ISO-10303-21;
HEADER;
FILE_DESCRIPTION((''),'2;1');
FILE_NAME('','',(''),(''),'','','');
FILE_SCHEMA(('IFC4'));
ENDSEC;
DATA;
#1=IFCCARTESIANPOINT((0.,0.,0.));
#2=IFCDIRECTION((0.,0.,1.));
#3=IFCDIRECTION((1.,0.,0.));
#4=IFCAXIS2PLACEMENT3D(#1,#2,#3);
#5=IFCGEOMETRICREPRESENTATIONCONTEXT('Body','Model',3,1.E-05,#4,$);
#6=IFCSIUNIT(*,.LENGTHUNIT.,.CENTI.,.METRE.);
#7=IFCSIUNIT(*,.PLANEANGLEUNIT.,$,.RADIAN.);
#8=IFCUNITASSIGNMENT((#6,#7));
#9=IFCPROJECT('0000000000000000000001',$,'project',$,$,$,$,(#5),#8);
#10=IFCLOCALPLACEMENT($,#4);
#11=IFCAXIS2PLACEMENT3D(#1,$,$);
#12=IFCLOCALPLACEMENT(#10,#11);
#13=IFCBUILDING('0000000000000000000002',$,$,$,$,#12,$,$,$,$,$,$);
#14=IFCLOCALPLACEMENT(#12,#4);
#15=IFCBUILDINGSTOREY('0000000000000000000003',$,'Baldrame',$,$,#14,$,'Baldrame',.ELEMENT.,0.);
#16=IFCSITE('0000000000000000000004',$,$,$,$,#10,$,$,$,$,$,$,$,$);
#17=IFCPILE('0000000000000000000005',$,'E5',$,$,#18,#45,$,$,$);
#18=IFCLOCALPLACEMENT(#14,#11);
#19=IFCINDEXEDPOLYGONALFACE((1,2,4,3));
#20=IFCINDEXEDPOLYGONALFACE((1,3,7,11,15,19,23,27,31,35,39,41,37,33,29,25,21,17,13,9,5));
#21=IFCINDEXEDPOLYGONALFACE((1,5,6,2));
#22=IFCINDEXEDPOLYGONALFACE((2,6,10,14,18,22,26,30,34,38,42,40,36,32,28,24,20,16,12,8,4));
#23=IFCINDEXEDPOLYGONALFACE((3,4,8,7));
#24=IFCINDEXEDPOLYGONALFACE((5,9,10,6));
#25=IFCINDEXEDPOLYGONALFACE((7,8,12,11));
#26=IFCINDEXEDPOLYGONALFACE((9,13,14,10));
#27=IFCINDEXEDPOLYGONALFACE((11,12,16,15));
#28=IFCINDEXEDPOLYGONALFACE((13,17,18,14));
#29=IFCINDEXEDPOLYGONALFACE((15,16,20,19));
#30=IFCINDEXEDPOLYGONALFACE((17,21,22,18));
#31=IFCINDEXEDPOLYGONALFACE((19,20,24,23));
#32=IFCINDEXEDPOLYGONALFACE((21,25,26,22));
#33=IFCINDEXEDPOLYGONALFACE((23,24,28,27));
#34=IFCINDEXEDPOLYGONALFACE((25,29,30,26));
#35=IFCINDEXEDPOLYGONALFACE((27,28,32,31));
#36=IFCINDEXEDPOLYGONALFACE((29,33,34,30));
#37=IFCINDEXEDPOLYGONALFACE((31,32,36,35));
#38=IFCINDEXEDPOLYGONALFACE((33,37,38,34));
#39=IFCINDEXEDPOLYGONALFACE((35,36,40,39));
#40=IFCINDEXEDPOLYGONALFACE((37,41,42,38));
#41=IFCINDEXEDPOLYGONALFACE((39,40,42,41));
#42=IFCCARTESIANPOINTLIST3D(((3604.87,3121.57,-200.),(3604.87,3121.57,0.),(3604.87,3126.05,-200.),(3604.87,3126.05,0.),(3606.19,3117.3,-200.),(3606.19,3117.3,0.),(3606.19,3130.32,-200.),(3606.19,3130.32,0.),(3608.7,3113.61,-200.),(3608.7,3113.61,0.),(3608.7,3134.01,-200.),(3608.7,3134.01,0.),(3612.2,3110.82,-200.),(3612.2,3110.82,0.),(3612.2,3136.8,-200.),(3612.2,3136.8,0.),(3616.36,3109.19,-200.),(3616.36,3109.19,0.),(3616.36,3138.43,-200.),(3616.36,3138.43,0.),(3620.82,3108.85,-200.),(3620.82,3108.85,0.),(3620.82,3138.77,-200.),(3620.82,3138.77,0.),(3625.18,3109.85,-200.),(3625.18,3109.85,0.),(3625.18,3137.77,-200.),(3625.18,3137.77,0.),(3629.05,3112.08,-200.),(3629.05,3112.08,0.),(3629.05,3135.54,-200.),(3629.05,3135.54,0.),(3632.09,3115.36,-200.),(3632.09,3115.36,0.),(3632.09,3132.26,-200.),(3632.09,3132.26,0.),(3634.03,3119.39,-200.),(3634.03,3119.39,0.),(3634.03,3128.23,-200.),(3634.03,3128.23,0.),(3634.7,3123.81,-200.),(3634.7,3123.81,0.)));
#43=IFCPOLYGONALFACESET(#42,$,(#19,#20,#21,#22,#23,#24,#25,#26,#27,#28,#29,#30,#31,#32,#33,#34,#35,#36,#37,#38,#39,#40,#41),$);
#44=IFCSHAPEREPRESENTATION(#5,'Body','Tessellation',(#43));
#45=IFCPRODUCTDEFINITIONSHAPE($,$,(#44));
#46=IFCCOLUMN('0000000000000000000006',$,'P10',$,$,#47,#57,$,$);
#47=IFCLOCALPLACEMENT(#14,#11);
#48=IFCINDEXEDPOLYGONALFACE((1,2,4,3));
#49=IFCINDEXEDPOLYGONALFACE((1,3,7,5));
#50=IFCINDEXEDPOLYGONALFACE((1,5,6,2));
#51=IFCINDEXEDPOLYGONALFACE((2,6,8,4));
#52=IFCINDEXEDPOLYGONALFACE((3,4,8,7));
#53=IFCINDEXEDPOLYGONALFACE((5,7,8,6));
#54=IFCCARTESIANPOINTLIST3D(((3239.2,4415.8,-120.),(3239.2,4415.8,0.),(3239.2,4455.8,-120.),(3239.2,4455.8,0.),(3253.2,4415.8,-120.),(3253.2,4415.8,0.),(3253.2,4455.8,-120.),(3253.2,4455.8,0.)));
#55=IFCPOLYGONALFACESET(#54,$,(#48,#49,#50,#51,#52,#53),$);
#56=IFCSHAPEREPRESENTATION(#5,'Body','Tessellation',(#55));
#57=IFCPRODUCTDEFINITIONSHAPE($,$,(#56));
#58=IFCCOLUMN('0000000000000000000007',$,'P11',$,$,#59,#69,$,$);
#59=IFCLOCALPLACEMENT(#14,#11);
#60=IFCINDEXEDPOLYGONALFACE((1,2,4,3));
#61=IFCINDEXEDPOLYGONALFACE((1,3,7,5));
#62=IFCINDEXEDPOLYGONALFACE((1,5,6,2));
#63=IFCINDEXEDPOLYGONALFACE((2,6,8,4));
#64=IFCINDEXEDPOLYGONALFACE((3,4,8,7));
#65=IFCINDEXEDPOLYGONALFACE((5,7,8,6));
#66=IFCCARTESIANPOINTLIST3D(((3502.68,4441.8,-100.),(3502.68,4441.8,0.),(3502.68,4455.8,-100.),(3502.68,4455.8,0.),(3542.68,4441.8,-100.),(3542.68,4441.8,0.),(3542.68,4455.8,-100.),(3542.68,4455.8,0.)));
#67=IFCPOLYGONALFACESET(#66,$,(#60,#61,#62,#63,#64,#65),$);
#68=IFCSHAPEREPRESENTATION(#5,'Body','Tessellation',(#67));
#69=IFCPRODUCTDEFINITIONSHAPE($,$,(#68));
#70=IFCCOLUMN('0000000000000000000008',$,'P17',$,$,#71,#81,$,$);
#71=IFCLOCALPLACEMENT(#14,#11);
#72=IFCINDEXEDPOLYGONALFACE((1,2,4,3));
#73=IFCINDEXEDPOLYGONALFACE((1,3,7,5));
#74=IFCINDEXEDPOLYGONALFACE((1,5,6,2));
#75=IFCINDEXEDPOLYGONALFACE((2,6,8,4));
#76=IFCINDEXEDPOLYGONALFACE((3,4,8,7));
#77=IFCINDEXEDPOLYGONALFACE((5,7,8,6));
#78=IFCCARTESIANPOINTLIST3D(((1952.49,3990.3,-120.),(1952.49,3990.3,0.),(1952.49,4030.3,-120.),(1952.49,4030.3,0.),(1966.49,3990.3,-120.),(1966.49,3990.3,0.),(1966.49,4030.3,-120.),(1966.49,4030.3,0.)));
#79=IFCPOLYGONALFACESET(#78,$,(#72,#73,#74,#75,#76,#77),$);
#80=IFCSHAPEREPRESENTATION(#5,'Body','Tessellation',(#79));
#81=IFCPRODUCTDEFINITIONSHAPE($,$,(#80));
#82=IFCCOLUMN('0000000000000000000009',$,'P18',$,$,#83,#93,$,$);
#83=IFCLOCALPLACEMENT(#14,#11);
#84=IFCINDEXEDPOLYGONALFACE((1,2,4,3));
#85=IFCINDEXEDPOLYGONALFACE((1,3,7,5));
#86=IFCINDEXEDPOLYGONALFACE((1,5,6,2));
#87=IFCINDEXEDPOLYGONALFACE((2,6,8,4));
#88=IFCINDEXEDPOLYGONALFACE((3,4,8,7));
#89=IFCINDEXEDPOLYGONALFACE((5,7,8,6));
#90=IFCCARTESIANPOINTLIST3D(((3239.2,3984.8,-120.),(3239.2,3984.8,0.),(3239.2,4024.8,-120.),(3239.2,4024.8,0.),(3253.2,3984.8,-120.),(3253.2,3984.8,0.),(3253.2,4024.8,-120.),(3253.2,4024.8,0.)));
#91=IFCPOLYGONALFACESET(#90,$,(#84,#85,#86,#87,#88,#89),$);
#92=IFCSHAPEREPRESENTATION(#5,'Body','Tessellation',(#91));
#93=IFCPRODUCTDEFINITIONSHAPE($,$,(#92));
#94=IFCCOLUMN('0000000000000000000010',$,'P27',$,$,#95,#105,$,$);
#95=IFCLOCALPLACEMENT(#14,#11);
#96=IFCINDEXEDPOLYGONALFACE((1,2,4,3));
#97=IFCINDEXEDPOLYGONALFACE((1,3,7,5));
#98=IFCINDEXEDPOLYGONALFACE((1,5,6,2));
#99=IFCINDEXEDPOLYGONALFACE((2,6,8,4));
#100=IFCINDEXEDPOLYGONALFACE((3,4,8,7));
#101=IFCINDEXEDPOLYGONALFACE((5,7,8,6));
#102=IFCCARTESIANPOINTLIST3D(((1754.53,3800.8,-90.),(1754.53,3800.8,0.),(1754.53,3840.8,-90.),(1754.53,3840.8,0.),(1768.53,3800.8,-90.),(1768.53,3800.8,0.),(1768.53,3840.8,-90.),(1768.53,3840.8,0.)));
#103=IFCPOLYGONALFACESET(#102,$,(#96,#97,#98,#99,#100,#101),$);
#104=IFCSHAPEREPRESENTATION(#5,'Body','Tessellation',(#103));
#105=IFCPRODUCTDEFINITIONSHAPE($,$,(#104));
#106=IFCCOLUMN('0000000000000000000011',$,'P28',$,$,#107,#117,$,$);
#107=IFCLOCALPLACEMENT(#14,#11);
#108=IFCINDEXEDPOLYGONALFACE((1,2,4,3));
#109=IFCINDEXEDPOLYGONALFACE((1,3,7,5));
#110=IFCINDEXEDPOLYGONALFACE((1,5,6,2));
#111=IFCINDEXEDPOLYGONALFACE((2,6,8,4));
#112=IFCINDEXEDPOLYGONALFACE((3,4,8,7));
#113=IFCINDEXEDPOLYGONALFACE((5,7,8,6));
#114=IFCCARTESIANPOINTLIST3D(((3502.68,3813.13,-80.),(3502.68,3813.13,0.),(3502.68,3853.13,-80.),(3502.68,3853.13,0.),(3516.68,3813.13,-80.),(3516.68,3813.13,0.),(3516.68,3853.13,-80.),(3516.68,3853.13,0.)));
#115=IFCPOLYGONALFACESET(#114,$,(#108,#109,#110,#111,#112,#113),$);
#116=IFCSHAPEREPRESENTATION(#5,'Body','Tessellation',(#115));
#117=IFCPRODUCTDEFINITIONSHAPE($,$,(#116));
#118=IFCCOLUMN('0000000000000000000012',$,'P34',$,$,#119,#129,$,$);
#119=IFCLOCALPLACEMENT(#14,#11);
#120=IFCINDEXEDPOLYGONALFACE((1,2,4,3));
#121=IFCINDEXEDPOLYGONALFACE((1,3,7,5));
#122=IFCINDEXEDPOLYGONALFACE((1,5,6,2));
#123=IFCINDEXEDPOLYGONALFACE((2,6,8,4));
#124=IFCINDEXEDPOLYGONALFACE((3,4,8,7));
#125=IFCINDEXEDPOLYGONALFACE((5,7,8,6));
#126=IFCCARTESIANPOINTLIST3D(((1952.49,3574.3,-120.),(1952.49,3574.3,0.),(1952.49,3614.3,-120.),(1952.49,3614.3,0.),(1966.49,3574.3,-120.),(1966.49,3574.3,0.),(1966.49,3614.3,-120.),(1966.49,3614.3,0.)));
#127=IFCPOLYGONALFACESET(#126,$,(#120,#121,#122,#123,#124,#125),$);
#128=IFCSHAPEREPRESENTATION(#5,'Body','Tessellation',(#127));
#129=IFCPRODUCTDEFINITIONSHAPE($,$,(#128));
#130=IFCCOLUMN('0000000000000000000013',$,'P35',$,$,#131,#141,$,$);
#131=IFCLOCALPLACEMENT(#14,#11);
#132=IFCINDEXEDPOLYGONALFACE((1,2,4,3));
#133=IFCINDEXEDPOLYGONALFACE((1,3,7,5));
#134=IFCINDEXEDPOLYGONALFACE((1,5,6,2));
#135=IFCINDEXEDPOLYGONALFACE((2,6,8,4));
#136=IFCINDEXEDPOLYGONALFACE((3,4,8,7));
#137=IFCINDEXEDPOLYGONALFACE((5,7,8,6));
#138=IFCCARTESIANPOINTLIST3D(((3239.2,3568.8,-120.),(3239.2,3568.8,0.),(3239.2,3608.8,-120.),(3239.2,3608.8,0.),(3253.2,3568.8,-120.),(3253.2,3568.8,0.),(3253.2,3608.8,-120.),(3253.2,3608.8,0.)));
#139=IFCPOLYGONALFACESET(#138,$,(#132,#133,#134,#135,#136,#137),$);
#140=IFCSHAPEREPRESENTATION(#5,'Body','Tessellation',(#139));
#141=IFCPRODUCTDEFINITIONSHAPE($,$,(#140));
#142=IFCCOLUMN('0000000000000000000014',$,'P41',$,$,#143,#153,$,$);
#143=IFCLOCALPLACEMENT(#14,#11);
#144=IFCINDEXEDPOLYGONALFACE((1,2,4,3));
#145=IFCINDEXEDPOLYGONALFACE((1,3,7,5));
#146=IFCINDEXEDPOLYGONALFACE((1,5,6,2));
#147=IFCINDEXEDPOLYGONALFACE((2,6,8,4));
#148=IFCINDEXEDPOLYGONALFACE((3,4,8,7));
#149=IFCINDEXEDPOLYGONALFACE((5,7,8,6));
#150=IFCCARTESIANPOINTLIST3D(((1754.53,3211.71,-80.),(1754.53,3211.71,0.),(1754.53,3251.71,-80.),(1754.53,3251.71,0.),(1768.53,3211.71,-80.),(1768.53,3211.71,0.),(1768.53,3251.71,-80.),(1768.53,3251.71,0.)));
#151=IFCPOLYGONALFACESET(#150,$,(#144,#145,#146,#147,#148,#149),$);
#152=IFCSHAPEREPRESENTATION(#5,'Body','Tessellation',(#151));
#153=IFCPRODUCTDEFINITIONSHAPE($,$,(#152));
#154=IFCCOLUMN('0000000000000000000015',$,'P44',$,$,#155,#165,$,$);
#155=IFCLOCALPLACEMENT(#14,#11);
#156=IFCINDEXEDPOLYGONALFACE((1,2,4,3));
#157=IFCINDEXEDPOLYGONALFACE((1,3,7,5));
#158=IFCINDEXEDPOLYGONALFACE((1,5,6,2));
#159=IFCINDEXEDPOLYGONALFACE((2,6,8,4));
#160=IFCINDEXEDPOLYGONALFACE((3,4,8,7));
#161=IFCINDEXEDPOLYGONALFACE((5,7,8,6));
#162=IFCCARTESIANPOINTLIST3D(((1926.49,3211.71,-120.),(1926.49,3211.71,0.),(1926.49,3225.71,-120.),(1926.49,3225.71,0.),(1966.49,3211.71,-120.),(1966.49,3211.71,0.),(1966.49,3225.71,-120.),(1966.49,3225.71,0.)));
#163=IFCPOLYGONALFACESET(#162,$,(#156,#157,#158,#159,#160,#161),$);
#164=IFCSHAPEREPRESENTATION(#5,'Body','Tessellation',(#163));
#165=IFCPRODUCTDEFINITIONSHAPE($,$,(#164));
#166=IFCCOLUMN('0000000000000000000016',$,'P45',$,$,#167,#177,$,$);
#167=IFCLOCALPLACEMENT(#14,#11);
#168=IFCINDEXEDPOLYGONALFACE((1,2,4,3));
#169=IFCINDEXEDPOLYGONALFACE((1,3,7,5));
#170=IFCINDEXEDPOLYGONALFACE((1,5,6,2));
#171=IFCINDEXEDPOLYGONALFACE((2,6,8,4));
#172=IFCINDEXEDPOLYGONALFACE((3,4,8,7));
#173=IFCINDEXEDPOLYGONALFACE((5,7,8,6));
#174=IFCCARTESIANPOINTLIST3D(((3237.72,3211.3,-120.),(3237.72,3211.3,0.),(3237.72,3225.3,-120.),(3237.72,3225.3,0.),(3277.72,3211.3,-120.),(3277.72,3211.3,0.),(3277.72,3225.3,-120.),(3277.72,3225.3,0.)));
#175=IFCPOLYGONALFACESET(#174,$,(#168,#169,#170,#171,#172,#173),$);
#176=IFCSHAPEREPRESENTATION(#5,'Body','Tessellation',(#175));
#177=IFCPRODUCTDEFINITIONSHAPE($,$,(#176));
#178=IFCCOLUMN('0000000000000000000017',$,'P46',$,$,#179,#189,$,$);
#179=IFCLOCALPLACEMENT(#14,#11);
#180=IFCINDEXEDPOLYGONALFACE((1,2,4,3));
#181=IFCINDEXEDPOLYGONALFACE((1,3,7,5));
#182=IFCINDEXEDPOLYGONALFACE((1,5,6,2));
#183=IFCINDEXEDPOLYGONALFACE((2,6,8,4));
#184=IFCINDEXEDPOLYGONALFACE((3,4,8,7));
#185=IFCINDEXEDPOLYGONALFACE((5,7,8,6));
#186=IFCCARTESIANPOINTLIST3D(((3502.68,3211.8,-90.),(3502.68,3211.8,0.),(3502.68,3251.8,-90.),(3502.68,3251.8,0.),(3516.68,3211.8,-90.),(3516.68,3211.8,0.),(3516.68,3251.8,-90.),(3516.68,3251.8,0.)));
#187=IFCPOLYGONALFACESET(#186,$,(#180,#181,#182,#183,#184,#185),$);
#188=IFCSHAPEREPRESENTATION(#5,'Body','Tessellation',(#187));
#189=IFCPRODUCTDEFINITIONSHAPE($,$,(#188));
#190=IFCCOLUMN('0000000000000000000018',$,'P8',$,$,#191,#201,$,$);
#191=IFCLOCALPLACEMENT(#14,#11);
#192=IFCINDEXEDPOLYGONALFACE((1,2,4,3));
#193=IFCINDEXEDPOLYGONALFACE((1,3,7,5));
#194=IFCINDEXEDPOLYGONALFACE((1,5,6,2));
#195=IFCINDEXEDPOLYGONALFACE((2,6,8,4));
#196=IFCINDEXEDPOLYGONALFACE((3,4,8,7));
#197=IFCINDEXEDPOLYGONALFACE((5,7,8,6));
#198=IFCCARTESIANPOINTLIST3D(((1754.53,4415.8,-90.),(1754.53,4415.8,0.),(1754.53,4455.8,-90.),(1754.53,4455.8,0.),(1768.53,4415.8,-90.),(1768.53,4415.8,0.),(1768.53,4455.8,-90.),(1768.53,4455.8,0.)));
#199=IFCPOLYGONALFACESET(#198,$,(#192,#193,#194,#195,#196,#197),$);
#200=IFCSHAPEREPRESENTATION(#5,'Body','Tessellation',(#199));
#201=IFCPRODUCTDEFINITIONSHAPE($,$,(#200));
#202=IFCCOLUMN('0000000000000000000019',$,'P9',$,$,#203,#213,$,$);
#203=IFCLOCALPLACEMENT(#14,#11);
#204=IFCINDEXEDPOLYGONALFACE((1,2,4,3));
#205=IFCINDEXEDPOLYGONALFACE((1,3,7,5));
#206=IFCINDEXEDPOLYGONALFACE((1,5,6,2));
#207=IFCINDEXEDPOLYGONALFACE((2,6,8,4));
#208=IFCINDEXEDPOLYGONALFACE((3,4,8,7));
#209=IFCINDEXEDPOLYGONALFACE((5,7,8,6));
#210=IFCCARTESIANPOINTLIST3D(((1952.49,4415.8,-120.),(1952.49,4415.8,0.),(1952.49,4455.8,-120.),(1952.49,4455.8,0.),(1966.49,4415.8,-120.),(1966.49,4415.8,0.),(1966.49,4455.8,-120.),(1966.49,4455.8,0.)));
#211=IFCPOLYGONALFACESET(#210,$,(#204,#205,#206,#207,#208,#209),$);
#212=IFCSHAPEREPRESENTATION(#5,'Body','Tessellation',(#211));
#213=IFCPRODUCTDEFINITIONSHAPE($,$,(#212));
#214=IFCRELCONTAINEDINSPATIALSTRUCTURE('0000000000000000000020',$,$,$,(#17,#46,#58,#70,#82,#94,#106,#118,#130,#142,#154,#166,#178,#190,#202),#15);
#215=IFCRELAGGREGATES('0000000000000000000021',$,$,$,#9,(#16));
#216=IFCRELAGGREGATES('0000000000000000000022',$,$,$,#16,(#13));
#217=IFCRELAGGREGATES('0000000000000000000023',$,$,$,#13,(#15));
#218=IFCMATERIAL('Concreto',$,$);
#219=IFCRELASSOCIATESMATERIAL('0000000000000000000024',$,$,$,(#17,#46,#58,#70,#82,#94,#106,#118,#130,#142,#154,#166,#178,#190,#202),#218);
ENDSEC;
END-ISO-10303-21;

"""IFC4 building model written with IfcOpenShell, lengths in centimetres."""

from ifc_helpers import new_model, si_unit, frame, origin, origin_with_axes, origin_2d_with_axis, place, context, project, spatial, rectangle, circle, extrude, material, element, save


model = new_model("IFC4")

# Units and contexts
model_context = context("Model", 3, precision=1e-05, world=origin_with_axes(), identifier="Body")
ifc_project = project(units=[si_unit("LENGTHUNIT", "METRE", prefix="CENTI"), si_unit("PLANEANGLEUNIT", "RADIAN")], contexts=[model_context])

# Site, building, storey
site_placement = place(None, origin_with_axes())
site = spatial("IfcSite", under=ifc_project, at=site_placement)
building_placement = place(site_placement, origin())
building = spatial("IfcBuilding", under=site, at=building_placement)
storey_placement = place(building_placement, origin_with_axes())
storey = spatial("IfcBuildingStorey", under=building, at=storey_placement, Name="Baldrame", LongName="Baldrame", CompositionType="ELEMENT", Elevation=0.0)

# Pile
ifc_material = material(Name="Concreto")
pile_placement = place(storey_placement, frame((3619.7, 3123.81, 0.0), z_axis=(0.0, 0.0, 1.0), x_axis=(1.0, 0.0, 0.0)))
element("IfcPile", 1, at=pile_placement, inside=storey, material=ifc_material, Name="E5", context=model_context, shape_type="SolidModel", body=[
    extrude(circle(Radius=15.0, at=origin_2d_with_axis()), frame((0.0, 0.0, -200.0), z_axis=(0.0, 0.0, 1.0), x_axis=(1.0, 0.0, 0.0)), (0.0, 0.0, 1.0), 200.0),
])

# Columns
column_1_placement = place(storey_placement, frame((3246.2, 4435.8, 0.0), z_axis=(0.0, 0.0, 1.0), x_axis=(1.0, 0.0, 0.0)))
element("IfcColumn", 2, at=column_1_placement, inside=storey, material=ifc_material, Name="P10", context=model_context, shape_type="SolidModel", body=[
    extrude(rectangle(XDim=14.0, YDim=40.0, at=origin_2d_with_axis()), frame((0.0, 0.0, -120.0), z_axis=(0.0, 0.0, 1.0), x_axis=(1.0, 0.0, 0.0)), (0.0, 0.0, 1.0), 120.0),
])
column_2_placement = place(storey_placement, frame((3522.68, 4448.8, 0.0), z_axis=(0.0, 0.0, 1.0), x_axis=(1.0, 0.0, 0.0)))
element("IfcColumn", 3, at=column_2_placement, inside=storey, material=ifc_material, Name="P11", context=model_context, shape_type="SolidModel", body=[
    extrude(rectangle(XDim=14.0, YDim=40.0, at=origin_2d_with_axis()), frame((0.0, 0.0, -100.0), z_axis=(0.0, 0.0, 1.0), x_axis=(0.0, -1.0, 0.0)), (0.0, 0.0, 1.0), 100.0),
])
for number, where, z_axis, x_axis, name in (
    (4, (1959.49, 4010.3, 0.0), (0.0, 0.0, 1.0), (1.0, 0.0, 0.0), "P17"),
    (5, (3246.2, 4004.8, 0.0), (0.0, 0.0, 1.0), (1.0, 0.0, 0.0), "P18"),
):
    element("IfcColumn", number, at=place(storey_placement, frame(where, z_axis=z_axis, x_axis=x_axis)), inside=storey, material=ifc_material, Name=name, context=model_context, shape_type="SolidModel", body=[
        extrude(rectangle(XDim=14.0, YDim=40.0, at=origin_2d_with_axis()), frame((0.0, 0.0, -120.0), z_axis=(0.0, 0.0, 1.0), x_axis=(1.0, 0.0, 0.0)), (0.0, 0.0, 1.0), 120.0),
    ])
column_3_placement = place(storey_placement, frame((1761.53, 3820.8, 0.0), z_axis=(0.0, 0.0, 1.0), x_axis=(1.0, 0.0, 0.0)))
element("IfcColumn", 6, at=column_3_placement, inside=storey, material=ifc_material, Name="P27", context=model_context, shape_type="SolidModel", body=[
    extrude(rectangle(XDim=14.0, YDim=40.0, at=origin_2d_with_axis()), frame((0.0, 0.0, -90.0), z_axis=(0.0, 0.0, 1.0), x_axis=(1.0, 0.0, 0.0)), (0.0, 0.0, 1.0), 90.0),
])
column_4_placement = place(storey_placement, frame((3509.68, 3833.13, 0.0), z_axis=(0.0, 0.0, 1.0), x_axis=(1.0, 0.0, 0.0)))
element("IfcColumn", 7, at=column_4_placement, inside=storey, material=ifc_material, Name="P28", context=model_context, shape_type="SolidModel", body=[
    extrude(rectangle(XDim=14.0, YDim=40.0, at=origin_2d_with_axis()), frame((0.0, 0.0, -80.0), z_axis=(0.0, 0.0, 1.0), x_axis=(1.0, 0.0, 0.0)), (0.0, 0.0, 1.0), 80.0),
])
for number, where, z_axis, x_axis, name in (
    (8, (1959.49, 3594.3, 0.0), (0.0, 0.0, 1.0), (1.0, 0.0, 0.0), "P34"),
    (9, (3246.2, 3588.8, 0.0), (0.0, 0.0, 1.0), (1.0, 0.0, 0.0), "P35"),
):
    element("IfcColumn", number, at=place(storey_placement, frame(where, z_axis=z_axis, x_axis=x_axis)), inside=storey, material=ifc_material, Name=name, context=model_context, shape_type="SolidModel", body=[
        extrude(rectangle(XDim=14.0, YDim=40.0, at=origin_2d_with_axis()), frame((0.0, 0.0, -120.0), z_axis=(0.0, 0.0, 1.0), x_axis=(1.0, 0.0, 0.0)), (0.0, 0.0, 1.0), 120.0),
    ])
column_5_placement = place(storey_placement, frame((1761.53, 3231.71, 0.0), z_axis=(0.0, 0.0, 1.0), x_axis=(1.0, 0.0, 0.0)))
element("IfcColumn", 10, at=column_5_placement, inside=storey, material=ifc_material, Name="P41", context=model_context, shape_type="SolidModel", body=[
    extrude(rectangle(XDim=14.0, YDim=40.0, at=origin_2d_with_axis()), frame((0.0, 0.0, -80.0), z_axis=(0.0, 0.0, 1.0), x_axis=(1.0, 0.0, 0.0)), (0.0, 0.0, 1.0), 80.0),
])
for number, where, z_axis, x_axis, name in (
    (11, (1946.49, 3218.71, 0.0), (0.0, 0.0, 1.0), (1.0, 0.0, 0.0), "P44"),
    (12, (3257.72, 3218.3, 0.0), (0.0, 0.0, 1.0), (1.0, 0.0, 0.0), "P45"),
):
    element("IfcColumn", number, at=place(storey_placement, frame(where, z_axis=z_axis, x_axis=x_axis)), inside=storey, material=ifc_material, Name=name, context=model_context, shape_type="SolidModel", body=[
        extrude(rectangle(XDim=14.0, YDim=40.0, at=origin_2d_with_axis()), frame((0.0, 0.0, -120.0), z_axis=(0.0, 0.0, 1.0), x_axis=(0.0, -1.0, 0.0)), (0.0, 0.0, 1.0), 120.0),
    ])
for number, where, z_axis, x_axis, name in (
    (13, (3509.68, 3231.8, 0.0), (0.0, 0.0, 1.0), (1.0, 0.0, 0.0), "P46"),
    (14, (1761.53, 4435.8, 0.0), (0.0, 0.0, 1.0), (1.0, 0.0, 0.0), "P8"),
):
    element("IfcColumn", number, at=place(storey_placement, frame(where, z_axis=z_axis, x_axis=x_axis)), inside=storey, material=ifc_material, Name=name, context=model_context, shape_type="SolidModel", body=[
        extrude(rectangle(XDim=14.0, YDim=40.0, at=origin_2d_with_axis()), frame((0.0, 0.0, -90.0), z_axis=(0.0, 0.0, 1.0), x_axis=(1.0, 0.0, 0.0)), (0.0, 0.0, 1.0), 90.0),
    ])
column_6_placement = place(storey_placement, frame((1959.49, 4435.8, 0.0), z_axis=(0.0, 0.0, 1.0), x_axis=(1.0, 0.0, 0.0)))
element("IfcColumn", 15, at=column_6_placement, inside=storey, material=ifc_material, Name="P9", context=model_context, shape_type="SolidModel", body=[
    extrude(rectangle(XDim=14.0, YDim=40.0, at=origin_2d_with_axis()), frame((0.0, 0.0, -120.0), z_axis=(0.0, 0.0, 1.0), x_axis=(1.0, 0.0, 0.0)), (0.0, 0.0, 1.0), 120.0),
])

save(model, "model.ifc")
